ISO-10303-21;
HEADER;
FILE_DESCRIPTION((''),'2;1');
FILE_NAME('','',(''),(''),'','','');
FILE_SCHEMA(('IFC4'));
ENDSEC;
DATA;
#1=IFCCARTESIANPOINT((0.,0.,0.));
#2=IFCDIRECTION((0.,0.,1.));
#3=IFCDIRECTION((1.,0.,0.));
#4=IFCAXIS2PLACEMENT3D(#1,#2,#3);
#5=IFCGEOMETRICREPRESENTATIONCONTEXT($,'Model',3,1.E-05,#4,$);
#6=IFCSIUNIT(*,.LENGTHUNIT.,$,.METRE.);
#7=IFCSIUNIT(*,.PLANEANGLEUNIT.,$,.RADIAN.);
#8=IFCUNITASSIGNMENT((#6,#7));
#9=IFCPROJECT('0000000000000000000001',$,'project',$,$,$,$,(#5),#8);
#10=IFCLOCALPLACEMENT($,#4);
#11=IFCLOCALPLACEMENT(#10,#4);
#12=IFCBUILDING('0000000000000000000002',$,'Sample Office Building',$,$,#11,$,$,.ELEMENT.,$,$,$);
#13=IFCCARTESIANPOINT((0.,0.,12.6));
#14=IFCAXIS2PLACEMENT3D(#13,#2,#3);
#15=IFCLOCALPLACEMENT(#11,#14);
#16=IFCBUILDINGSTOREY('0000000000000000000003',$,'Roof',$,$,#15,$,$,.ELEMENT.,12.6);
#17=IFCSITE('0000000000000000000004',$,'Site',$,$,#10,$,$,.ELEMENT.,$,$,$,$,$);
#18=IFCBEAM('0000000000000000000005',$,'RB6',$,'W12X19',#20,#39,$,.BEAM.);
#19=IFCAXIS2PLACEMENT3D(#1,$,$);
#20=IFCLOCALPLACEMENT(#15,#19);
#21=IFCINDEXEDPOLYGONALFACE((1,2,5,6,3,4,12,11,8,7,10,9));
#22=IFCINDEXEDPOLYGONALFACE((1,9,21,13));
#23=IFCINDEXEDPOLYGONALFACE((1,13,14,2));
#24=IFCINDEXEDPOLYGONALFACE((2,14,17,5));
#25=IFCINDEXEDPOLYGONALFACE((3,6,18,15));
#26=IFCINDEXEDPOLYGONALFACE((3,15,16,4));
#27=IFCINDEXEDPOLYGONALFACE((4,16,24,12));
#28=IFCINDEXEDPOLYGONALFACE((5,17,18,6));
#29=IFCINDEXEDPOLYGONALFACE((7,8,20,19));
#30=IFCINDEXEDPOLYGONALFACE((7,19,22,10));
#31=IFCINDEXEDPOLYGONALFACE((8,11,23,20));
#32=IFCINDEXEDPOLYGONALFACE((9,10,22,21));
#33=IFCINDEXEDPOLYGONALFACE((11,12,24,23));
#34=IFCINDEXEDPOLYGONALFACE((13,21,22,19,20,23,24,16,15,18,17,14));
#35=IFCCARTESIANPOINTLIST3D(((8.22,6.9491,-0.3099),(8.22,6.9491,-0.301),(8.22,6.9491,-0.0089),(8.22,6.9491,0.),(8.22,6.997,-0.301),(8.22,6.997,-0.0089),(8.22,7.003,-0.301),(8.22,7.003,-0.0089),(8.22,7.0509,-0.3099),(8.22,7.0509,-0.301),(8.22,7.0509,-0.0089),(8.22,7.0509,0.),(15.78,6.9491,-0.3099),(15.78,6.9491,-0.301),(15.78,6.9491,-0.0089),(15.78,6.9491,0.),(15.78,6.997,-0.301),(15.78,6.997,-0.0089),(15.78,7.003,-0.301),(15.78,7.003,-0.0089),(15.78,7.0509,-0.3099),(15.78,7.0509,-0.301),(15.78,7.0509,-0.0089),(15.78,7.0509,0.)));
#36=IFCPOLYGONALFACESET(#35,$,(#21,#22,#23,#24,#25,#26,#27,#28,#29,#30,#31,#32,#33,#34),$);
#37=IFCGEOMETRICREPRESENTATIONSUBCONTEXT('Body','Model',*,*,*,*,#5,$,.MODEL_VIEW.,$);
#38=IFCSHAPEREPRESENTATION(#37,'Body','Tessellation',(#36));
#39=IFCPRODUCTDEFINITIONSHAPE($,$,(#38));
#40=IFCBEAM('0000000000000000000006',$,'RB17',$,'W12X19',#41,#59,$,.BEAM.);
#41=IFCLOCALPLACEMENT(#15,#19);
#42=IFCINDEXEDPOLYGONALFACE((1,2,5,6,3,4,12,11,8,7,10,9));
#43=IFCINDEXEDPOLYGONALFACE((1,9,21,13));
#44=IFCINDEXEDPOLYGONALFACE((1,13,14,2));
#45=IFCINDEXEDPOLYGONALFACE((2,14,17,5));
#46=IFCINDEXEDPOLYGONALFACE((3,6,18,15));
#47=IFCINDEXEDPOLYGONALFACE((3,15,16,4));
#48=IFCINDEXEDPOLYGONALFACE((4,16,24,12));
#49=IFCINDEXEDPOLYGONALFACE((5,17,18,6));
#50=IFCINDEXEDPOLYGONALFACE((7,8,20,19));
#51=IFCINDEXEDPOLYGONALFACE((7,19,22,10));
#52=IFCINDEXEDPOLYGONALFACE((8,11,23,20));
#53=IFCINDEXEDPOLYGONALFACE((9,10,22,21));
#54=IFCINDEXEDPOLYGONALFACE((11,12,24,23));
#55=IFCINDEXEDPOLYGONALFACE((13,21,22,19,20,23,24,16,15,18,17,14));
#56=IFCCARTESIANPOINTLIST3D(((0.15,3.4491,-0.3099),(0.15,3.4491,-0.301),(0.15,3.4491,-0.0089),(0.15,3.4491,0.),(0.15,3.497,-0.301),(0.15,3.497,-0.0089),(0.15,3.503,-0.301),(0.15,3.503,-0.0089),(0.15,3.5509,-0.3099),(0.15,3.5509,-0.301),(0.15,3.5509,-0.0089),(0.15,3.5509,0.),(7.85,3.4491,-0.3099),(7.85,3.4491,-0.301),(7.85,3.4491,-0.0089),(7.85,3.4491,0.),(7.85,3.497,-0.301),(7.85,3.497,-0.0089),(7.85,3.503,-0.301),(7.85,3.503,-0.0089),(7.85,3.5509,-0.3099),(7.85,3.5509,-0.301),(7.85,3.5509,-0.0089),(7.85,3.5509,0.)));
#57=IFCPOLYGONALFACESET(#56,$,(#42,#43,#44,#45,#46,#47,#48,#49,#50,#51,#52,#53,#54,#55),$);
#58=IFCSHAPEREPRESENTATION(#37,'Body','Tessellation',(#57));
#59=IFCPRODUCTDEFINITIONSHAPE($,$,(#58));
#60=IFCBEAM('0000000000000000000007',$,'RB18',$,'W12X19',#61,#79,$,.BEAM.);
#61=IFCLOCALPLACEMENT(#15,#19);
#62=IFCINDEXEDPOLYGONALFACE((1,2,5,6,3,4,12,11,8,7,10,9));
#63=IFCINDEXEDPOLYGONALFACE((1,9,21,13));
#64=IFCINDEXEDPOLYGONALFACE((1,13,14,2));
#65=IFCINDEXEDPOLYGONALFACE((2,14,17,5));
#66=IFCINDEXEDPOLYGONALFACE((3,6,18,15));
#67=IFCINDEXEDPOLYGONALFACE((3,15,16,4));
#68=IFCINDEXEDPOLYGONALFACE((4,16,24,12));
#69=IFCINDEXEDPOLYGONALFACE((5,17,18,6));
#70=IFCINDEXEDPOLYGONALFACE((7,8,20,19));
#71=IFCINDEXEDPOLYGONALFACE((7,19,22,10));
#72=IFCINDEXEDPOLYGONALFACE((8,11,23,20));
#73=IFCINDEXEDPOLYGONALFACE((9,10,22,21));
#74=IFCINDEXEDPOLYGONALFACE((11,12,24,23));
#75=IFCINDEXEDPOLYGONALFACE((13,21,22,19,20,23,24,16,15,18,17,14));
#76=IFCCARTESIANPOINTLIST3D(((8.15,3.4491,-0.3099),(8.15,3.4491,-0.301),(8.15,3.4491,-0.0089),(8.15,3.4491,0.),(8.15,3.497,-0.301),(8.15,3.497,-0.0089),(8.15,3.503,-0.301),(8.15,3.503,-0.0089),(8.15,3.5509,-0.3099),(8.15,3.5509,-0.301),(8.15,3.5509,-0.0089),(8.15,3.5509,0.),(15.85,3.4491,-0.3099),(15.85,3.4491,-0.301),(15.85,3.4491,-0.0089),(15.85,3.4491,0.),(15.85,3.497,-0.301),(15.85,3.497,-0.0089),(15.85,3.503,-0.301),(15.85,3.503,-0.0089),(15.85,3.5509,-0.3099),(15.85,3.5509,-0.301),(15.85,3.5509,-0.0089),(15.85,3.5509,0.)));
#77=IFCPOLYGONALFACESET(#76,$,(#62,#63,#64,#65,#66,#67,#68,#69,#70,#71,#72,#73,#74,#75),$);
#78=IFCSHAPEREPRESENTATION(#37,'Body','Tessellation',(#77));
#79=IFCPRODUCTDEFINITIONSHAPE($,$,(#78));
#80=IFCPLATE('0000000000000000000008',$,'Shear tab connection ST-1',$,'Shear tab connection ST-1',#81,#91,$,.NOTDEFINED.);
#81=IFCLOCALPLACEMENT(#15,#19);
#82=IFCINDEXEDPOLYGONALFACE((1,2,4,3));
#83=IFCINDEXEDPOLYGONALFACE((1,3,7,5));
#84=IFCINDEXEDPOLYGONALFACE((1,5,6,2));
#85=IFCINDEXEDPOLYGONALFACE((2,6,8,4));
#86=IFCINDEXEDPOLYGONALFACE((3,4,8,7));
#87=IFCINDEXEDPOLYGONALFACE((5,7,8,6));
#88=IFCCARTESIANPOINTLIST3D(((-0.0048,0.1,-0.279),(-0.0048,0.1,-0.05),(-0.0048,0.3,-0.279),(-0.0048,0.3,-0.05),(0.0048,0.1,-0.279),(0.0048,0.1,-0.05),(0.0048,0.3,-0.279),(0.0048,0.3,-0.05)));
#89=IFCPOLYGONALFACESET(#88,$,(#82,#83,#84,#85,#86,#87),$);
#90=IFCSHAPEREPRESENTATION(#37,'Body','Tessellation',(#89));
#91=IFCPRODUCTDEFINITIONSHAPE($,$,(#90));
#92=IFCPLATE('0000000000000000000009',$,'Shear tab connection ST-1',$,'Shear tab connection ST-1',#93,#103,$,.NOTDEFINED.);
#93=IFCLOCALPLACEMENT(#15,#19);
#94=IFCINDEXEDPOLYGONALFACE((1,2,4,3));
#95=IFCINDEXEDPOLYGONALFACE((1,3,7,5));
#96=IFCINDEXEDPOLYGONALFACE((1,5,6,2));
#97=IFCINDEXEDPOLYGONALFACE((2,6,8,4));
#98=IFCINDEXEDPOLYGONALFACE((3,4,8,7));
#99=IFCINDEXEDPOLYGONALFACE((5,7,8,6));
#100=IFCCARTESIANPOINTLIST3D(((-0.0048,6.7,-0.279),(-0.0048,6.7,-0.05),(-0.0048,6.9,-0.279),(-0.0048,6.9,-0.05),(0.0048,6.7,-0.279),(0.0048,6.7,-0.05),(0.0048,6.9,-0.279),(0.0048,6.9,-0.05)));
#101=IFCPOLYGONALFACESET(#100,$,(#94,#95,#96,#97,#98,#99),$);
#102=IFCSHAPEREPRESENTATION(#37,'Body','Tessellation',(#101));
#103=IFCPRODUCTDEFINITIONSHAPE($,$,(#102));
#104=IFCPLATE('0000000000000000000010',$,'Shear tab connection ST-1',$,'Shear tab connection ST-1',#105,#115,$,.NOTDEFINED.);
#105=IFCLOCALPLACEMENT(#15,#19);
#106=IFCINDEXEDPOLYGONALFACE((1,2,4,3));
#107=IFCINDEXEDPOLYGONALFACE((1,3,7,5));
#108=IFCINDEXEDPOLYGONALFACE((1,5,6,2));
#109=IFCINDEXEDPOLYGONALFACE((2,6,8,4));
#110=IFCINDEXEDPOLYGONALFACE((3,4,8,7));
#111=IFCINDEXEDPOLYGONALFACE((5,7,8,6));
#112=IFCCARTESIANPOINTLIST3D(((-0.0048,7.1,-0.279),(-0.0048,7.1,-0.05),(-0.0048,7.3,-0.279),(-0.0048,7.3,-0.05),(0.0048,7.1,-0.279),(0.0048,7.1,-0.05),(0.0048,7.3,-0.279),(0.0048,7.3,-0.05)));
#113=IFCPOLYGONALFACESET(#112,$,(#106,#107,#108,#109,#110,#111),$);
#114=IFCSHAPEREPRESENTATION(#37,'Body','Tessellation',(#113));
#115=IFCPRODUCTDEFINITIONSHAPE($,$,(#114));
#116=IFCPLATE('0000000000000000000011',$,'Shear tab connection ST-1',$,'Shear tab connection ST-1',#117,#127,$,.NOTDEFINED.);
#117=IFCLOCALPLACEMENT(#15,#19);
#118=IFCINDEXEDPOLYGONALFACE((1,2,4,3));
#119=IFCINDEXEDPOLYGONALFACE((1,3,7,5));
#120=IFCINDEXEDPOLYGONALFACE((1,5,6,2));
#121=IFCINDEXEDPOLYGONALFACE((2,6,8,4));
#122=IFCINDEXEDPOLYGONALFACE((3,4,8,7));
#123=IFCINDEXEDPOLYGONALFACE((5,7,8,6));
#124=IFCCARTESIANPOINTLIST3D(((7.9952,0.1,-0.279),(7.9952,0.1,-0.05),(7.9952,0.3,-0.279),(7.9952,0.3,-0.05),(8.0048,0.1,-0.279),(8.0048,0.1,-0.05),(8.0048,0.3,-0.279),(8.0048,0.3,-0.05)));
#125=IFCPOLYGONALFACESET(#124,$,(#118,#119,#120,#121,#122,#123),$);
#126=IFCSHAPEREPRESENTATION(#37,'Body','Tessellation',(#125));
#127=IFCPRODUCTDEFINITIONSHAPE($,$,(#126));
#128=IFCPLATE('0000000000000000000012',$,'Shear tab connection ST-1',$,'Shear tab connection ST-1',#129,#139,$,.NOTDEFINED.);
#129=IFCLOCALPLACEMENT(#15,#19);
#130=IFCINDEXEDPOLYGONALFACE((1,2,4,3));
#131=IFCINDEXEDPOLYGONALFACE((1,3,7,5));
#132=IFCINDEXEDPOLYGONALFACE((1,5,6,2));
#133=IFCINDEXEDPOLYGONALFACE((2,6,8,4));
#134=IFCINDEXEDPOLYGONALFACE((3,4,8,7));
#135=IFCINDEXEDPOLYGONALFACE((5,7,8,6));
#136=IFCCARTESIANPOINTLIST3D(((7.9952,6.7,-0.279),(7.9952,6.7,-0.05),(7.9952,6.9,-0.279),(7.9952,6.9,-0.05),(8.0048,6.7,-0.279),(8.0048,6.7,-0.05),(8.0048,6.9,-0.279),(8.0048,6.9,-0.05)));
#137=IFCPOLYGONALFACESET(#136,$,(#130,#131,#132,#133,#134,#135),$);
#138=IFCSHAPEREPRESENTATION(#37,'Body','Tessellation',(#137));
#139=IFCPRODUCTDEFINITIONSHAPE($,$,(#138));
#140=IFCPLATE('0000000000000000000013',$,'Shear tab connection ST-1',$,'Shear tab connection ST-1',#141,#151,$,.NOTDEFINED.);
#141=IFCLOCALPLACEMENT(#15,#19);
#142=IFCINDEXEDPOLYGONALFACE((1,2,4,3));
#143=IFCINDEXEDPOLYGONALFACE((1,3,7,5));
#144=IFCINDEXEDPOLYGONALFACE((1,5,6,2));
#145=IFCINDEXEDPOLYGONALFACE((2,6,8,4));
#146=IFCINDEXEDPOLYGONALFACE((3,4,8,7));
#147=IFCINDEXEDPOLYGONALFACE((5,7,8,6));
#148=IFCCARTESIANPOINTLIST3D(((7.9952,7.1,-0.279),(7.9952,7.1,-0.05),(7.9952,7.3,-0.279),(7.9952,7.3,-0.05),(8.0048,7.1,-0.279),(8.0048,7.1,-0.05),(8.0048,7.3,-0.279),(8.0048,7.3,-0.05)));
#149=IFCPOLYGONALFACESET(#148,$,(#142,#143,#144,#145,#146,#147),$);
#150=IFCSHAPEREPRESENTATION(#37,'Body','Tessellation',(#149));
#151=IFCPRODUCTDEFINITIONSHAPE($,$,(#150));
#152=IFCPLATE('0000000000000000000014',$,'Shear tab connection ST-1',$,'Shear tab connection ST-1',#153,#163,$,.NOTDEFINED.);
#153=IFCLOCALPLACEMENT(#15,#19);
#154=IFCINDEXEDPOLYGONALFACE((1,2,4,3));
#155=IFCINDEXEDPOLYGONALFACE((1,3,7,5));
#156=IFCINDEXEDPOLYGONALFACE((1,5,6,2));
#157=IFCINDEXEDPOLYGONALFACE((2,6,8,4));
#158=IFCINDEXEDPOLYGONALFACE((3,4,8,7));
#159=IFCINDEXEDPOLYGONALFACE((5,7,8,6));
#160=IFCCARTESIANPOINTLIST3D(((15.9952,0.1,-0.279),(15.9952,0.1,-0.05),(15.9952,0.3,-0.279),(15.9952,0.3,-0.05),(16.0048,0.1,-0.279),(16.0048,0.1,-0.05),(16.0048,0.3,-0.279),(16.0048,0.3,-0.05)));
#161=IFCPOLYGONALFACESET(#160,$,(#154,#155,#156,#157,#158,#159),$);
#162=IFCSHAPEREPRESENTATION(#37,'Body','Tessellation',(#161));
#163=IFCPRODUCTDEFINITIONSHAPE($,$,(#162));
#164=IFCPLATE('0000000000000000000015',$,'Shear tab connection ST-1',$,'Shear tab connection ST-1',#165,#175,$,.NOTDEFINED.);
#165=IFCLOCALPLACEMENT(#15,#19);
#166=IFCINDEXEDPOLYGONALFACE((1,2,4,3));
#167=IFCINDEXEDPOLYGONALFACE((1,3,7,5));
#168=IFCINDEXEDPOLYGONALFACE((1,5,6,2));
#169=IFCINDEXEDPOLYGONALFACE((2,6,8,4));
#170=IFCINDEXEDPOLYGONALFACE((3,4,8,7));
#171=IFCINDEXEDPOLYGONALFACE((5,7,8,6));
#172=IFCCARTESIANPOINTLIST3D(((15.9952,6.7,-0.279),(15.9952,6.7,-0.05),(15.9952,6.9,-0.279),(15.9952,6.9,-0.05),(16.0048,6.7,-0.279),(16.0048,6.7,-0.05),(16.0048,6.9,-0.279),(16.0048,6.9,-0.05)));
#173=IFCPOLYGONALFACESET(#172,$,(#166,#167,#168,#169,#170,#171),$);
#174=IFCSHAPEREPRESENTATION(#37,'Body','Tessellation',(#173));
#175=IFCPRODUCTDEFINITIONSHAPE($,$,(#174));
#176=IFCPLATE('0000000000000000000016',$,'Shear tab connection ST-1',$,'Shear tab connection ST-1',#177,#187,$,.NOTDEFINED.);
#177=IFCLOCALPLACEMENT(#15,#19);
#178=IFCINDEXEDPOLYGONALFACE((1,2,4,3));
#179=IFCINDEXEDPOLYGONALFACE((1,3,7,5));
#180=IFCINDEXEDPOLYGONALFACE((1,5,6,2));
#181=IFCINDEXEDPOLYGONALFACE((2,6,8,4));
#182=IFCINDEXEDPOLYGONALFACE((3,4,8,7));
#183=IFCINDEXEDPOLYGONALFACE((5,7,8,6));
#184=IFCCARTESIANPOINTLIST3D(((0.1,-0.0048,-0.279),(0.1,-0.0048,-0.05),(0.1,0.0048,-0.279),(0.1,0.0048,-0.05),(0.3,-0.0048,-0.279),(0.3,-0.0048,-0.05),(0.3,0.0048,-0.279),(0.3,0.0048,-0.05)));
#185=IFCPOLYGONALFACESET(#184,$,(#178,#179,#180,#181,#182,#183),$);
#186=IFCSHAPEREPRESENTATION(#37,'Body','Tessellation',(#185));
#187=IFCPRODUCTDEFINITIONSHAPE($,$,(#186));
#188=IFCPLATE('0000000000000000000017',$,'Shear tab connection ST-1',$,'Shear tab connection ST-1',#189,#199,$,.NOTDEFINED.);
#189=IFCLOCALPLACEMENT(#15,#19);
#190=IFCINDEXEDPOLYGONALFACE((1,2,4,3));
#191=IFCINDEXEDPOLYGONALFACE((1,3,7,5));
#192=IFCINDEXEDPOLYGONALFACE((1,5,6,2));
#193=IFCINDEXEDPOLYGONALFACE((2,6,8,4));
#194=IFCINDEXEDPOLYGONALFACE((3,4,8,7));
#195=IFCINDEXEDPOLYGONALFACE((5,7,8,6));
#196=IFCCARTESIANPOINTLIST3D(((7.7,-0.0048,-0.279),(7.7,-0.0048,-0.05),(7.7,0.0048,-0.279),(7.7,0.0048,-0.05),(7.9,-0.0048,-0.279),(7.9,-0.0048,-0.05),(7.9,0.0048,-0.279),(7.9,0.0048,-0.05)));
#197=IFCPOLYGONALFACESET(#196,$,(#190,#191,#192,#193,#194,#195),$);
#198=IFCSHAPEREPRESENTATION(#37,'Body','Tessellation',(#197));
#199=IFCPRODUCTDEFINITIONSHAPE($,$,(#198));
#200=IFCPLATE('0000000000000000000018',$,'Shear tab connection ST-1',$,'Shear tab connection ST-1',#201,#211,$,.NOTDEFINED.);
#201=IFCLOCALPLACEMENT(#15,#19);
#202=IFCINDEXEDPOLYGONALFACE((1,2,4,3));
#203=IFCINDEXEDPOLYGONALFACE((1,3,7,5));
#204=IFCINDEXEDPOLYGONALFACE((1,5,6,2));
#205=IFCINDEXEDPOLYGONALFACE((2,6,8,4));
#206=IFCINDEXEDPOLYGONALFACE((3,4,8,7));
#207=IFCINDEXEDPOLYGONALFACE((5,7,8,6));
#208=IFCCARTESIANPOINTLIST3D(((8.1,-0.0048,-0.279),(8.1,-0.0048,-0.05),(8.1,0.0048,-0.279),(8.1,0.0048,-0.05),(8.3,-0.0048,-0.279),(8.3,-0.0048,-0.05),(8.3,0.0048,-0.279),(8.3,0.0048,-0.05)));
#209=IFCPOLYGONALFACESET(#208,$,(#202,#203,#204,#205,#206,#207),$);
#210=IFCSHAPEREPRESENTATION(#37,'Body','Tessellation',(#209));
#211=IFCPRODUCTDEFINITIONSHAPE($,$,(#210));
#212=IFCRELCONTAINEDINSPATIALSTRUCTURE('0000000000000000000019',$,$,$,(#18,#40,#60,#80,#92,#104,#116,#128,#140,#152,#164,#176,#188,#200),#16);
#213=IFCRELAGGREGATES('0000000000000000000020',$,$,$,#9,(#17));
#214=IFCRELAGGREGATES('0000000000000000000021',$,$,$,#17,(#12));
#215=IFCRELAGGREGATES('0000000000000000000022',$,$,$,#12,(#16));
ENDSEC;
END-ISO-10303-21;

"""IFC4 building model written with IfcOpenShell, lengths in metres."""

from ifc_helpers import new_model, si_unit, frame, origin_with_axes, place, context, subcontext, project, spatial, rectangle, i_section, extrude, element, save


model = new_model("IFC4")

# Units and contexts
model_context = context("Model", 3, precision=1e-05, world=origin_with_axes())
body_context = subcontext(model_context, "Body", "Model", "MODEL_VIEW")
ifc_project = project(units=[si_unit("LENGTHUNIT", "METRE"), si_unit("PLANEANGLEUNIT", "RADIAN")], contexts=[model_context])

# Site, building, storey
site_placement = place(None, origin_with_axes())
site = spatial("IfcSite", under=ifc_project, at=site_placement, Name="Site", CompositionType="ELEMENT")
building_placement = place(site_placement, origin_with_axes())
building = spatial("IfcBuilding", under=site, at=building_placement, Name="Sample Office Building", CompositionType="ELEMENT")
storey_placement = place(building_placement, frame((0.0, 0.0, 12.6), z_axis=(0.0, 0.0, 1.0), x_axis=(1.0, 0.0, 0.0)))
storey = spatial("IfcBuildingStorey", under=building, at=storey_placement, Name="Roof", CompositionType="ELEMENT", Elevation=12.6)

# Beams
beam_1_placement = place(None, frame((8.22, 7.0, 12.4451), z_axis=(1.0, 0.0, 0.0), x_axis=(0.0, 1.0, 0.0)))
element("IfcBeam", 1, at=beam_1_placement, inside=storey, Name="RB6", ObjectType="W12X19", PredefinedType="BEAM", context=body_context, shape_type="SweptSolid", body=[
    extrude(i_section(OverallWidth=0.1019, OverallDepth=0.3099, WebThickness=0.006, FlangeThickness=0.0089), None, (0.0, 0.0, 1.0), 7.56),
])
for number, where, z_axis, x_axis, name in (
    (2, (0.15, 3.5, 12.4451), (1.0, 0.0, 0.0), (0.0, 1.0, 0.0), "RB17"),
    (3, (8.15, 3.5, 12.4451), (1.0, 0.0, 0.0), (0.0, 1.0, 0.0), "RB18"),
):
    element("IfcBeam", number, at=place(None, frame(where, z_axis=z_axis, x_axis=x_axis)), inside=storey, Name=name, ObjectType="W12X19", PredefinedType="BEAM", context=body_context, shape_type="SweptSolid", body=[
        extrude(i_section(OverallWidth=0.1019, OverallDepth=0.3099, WebThickness=0.006, FlangeThickness=0.0089), None, (0.0, 0.0, 1.0), 7.7),
    ])

# Plates
plate_1_placement = place(None, frame((0.0, 0.2, 12.321), z_axis=(0.0, 0.0, 1.0), x_axis=(1.0, 0.0, 0.0)))
element("IfcPlate", 4, at=plate_1_placement, inside=storey, Name="Shear tab connection ST-1", ObjectType="Shear tab connection ST-1", PredefinedType="NOTDEFINED", context=body_context, shape_type="SweptSolid", body=[
    extrude(rectangle(XDim=0.0095, YDim=0.2), None, (0.0, 0.0, 1.0), 0.229),
])
for number, where, z_axis, x_axis, name in (
    (5, (0.0, 6.8, 12.321), (0.0, 0.0, 1.0), (1.0, 0.0, 0.0), "Shear tab connection ST-1"),
    (6, (0.0, 7.2, 12.321), (0.0, 0.0, 1.0), (1.0, 0.0, 0.0), "Shear tab connection ST-1"),
):
    element("IfcPlate", number, at=place(None, frame(where, z_axis=z_axis, x_axis=x_axis)), inside=storey, Name=name, ObjectType="Shear tab connection ST-1", PredefinedType="NOTDEFINED", context=body_context, shape_type="SweptSolid", body=[
        extrude(rectangle(XDim=0.0095, YDim=0.2), None, (0.0, 0.0, 1.0), 0.229),
    ])
plate_2_placement = place(None, frame((8.0, 0.2, 12.321), z_axis=(0.0, 0.0, 1.0), x_axis=(1.0, 0.0, 0.0)))
element("IfcPlate", 7, at=plate_2_placement, inside=storey, Name="Shear tab connection ST-1", ObjectType="Shear tab connection ST-1", PredefinedType="NOTDEFINED", context=body_context, shape_type="SweptSolid", body=[
    extrude(rectangle(XDim=0.0095, YDim=0.2), None, (0.0, 0.0, 1.0), 0.229),
])
for number, where, z_axis, x_axis, name in (
    (8, (8.0, 6.8, 12.321), (0.0, 0.0, 1.0), (1.0, 0.0, 0.0), "Shear tab connection ST-1"),
    (9, (8.0, 7.2, 12.321), (0.0, 0.0, 1.0), (1.0, 0.0, 0.0), "Shear tab connection ST-1"),
):
    element("IfcPlate", number, at=place(None, frame(where, z_axis=z_axis, x_axis=x_axis)), inside=storey, Name=name, ObjectType="Shear tab connection ST-1", PredefinedType="NOTDEFINED", context=body_context, shape_type="SweptSolid", body=[
        extrude(rectangle(XDim=0.0095, YDim=0.2), None, (0.0, 0.0, 1.0), 0.229),
    ])
plate_3_placement = place(None, frame((16.0, 0.2, 12.321), z_axis=(0.0, 0.0, 1.0), x_axis=(1.0, 0.0, 0.0)))
element("IfcPlate", 10, at=plate_3_placement, inside=storey, Name="Shear tab connection ST-1", ObjectType="Shear tab connection ST-1", PredefinedType="NOTDEFINED", context=body_context, shape_type="SweptSolid", body=[
    extrude(rectangle(XDim=0.0095, YDim=0.2), None, (0.0, 0.0, 1.0), 0.229),
])
plate_4_placement = place(None, frame((16.0, 6.8, 12.321), z_axis=(0.0, 0.0, 1.0), x_axis=(1.0, 0.0, 0.0)))
element("IfcPlate", 11, at=plate_4_placement, inside=storey, Name="Shear tab connection ST-1", ObjectType="Shear tab connection ST-1", PredefinedType="NOTDEFINED", context=body_context, shape_type="SweptSolid", body=[
    extrude(rectangle(XDim=0.0095, YDim=0.2), None, (0.0, 0.0, 1.0), 0.229),
])
plate_5_placement = place(None, frame((0.2, 0.0, 12.321), z_axis=(0.0, 0.0, 1.0), x_axis=(1.0, 0.0, 0.0)))
element("IfcPlate", 12, at=plate_5_placement, inside=storey, Name="Shear tab connection ST-1", ObjectType="Shear tab connection ST-1", PredefinedType="NOTDEFINED", context=body_context, shape_type="SweptSolid", body=[
    extrude(rectangle(XDim=0.2, YDim=0.0095), None, (0.0, 0.0, 1.0), 0.229),
])
plate_6_placement = place(None, frame((7.8, 0.0, 12.321), z_axis=(0.0, 0.0, 1.0), x_axis=(1.0, 0.0, 0.0)))
element("IfcPlate", 13, at=plate_6_placement, inside=storey, Name="Shear tab connection ST-1", ObjectType="Shear tab connection ST-1", PredefinedType="NOTDEFINED", context=body_context, shape_type="SweptSolid", body=[
    extrude(rectangle(XDim=0.2, YDim=0.0095), None, (0.0, 0.0, 1.0), 0.229),
])
for number, where, z_axis, x_axis, name in (
    (14, (8.2, 0.0, 12.321), (0.0, 0.0, 1.0), (1.0, 0.0, 0.0), "Shear tab connection ST-1"),
):
    element("IfcPlate", number, at=place(None, frame(where, z_axis=z_axis, x_axis=x_axis)), inside=storey, Name=name, ObjectType="Shear tab connection ST-1", PredefinedType="NOTDEFINED", context=body_context, shape_type="SweptSolid", body=[
        extrude(rectangle(XDim=0.2, YDim=0.0095), None, (0.0, 0.0, 1.0), 0.229),
    ])

save(model, "model.ifc")
